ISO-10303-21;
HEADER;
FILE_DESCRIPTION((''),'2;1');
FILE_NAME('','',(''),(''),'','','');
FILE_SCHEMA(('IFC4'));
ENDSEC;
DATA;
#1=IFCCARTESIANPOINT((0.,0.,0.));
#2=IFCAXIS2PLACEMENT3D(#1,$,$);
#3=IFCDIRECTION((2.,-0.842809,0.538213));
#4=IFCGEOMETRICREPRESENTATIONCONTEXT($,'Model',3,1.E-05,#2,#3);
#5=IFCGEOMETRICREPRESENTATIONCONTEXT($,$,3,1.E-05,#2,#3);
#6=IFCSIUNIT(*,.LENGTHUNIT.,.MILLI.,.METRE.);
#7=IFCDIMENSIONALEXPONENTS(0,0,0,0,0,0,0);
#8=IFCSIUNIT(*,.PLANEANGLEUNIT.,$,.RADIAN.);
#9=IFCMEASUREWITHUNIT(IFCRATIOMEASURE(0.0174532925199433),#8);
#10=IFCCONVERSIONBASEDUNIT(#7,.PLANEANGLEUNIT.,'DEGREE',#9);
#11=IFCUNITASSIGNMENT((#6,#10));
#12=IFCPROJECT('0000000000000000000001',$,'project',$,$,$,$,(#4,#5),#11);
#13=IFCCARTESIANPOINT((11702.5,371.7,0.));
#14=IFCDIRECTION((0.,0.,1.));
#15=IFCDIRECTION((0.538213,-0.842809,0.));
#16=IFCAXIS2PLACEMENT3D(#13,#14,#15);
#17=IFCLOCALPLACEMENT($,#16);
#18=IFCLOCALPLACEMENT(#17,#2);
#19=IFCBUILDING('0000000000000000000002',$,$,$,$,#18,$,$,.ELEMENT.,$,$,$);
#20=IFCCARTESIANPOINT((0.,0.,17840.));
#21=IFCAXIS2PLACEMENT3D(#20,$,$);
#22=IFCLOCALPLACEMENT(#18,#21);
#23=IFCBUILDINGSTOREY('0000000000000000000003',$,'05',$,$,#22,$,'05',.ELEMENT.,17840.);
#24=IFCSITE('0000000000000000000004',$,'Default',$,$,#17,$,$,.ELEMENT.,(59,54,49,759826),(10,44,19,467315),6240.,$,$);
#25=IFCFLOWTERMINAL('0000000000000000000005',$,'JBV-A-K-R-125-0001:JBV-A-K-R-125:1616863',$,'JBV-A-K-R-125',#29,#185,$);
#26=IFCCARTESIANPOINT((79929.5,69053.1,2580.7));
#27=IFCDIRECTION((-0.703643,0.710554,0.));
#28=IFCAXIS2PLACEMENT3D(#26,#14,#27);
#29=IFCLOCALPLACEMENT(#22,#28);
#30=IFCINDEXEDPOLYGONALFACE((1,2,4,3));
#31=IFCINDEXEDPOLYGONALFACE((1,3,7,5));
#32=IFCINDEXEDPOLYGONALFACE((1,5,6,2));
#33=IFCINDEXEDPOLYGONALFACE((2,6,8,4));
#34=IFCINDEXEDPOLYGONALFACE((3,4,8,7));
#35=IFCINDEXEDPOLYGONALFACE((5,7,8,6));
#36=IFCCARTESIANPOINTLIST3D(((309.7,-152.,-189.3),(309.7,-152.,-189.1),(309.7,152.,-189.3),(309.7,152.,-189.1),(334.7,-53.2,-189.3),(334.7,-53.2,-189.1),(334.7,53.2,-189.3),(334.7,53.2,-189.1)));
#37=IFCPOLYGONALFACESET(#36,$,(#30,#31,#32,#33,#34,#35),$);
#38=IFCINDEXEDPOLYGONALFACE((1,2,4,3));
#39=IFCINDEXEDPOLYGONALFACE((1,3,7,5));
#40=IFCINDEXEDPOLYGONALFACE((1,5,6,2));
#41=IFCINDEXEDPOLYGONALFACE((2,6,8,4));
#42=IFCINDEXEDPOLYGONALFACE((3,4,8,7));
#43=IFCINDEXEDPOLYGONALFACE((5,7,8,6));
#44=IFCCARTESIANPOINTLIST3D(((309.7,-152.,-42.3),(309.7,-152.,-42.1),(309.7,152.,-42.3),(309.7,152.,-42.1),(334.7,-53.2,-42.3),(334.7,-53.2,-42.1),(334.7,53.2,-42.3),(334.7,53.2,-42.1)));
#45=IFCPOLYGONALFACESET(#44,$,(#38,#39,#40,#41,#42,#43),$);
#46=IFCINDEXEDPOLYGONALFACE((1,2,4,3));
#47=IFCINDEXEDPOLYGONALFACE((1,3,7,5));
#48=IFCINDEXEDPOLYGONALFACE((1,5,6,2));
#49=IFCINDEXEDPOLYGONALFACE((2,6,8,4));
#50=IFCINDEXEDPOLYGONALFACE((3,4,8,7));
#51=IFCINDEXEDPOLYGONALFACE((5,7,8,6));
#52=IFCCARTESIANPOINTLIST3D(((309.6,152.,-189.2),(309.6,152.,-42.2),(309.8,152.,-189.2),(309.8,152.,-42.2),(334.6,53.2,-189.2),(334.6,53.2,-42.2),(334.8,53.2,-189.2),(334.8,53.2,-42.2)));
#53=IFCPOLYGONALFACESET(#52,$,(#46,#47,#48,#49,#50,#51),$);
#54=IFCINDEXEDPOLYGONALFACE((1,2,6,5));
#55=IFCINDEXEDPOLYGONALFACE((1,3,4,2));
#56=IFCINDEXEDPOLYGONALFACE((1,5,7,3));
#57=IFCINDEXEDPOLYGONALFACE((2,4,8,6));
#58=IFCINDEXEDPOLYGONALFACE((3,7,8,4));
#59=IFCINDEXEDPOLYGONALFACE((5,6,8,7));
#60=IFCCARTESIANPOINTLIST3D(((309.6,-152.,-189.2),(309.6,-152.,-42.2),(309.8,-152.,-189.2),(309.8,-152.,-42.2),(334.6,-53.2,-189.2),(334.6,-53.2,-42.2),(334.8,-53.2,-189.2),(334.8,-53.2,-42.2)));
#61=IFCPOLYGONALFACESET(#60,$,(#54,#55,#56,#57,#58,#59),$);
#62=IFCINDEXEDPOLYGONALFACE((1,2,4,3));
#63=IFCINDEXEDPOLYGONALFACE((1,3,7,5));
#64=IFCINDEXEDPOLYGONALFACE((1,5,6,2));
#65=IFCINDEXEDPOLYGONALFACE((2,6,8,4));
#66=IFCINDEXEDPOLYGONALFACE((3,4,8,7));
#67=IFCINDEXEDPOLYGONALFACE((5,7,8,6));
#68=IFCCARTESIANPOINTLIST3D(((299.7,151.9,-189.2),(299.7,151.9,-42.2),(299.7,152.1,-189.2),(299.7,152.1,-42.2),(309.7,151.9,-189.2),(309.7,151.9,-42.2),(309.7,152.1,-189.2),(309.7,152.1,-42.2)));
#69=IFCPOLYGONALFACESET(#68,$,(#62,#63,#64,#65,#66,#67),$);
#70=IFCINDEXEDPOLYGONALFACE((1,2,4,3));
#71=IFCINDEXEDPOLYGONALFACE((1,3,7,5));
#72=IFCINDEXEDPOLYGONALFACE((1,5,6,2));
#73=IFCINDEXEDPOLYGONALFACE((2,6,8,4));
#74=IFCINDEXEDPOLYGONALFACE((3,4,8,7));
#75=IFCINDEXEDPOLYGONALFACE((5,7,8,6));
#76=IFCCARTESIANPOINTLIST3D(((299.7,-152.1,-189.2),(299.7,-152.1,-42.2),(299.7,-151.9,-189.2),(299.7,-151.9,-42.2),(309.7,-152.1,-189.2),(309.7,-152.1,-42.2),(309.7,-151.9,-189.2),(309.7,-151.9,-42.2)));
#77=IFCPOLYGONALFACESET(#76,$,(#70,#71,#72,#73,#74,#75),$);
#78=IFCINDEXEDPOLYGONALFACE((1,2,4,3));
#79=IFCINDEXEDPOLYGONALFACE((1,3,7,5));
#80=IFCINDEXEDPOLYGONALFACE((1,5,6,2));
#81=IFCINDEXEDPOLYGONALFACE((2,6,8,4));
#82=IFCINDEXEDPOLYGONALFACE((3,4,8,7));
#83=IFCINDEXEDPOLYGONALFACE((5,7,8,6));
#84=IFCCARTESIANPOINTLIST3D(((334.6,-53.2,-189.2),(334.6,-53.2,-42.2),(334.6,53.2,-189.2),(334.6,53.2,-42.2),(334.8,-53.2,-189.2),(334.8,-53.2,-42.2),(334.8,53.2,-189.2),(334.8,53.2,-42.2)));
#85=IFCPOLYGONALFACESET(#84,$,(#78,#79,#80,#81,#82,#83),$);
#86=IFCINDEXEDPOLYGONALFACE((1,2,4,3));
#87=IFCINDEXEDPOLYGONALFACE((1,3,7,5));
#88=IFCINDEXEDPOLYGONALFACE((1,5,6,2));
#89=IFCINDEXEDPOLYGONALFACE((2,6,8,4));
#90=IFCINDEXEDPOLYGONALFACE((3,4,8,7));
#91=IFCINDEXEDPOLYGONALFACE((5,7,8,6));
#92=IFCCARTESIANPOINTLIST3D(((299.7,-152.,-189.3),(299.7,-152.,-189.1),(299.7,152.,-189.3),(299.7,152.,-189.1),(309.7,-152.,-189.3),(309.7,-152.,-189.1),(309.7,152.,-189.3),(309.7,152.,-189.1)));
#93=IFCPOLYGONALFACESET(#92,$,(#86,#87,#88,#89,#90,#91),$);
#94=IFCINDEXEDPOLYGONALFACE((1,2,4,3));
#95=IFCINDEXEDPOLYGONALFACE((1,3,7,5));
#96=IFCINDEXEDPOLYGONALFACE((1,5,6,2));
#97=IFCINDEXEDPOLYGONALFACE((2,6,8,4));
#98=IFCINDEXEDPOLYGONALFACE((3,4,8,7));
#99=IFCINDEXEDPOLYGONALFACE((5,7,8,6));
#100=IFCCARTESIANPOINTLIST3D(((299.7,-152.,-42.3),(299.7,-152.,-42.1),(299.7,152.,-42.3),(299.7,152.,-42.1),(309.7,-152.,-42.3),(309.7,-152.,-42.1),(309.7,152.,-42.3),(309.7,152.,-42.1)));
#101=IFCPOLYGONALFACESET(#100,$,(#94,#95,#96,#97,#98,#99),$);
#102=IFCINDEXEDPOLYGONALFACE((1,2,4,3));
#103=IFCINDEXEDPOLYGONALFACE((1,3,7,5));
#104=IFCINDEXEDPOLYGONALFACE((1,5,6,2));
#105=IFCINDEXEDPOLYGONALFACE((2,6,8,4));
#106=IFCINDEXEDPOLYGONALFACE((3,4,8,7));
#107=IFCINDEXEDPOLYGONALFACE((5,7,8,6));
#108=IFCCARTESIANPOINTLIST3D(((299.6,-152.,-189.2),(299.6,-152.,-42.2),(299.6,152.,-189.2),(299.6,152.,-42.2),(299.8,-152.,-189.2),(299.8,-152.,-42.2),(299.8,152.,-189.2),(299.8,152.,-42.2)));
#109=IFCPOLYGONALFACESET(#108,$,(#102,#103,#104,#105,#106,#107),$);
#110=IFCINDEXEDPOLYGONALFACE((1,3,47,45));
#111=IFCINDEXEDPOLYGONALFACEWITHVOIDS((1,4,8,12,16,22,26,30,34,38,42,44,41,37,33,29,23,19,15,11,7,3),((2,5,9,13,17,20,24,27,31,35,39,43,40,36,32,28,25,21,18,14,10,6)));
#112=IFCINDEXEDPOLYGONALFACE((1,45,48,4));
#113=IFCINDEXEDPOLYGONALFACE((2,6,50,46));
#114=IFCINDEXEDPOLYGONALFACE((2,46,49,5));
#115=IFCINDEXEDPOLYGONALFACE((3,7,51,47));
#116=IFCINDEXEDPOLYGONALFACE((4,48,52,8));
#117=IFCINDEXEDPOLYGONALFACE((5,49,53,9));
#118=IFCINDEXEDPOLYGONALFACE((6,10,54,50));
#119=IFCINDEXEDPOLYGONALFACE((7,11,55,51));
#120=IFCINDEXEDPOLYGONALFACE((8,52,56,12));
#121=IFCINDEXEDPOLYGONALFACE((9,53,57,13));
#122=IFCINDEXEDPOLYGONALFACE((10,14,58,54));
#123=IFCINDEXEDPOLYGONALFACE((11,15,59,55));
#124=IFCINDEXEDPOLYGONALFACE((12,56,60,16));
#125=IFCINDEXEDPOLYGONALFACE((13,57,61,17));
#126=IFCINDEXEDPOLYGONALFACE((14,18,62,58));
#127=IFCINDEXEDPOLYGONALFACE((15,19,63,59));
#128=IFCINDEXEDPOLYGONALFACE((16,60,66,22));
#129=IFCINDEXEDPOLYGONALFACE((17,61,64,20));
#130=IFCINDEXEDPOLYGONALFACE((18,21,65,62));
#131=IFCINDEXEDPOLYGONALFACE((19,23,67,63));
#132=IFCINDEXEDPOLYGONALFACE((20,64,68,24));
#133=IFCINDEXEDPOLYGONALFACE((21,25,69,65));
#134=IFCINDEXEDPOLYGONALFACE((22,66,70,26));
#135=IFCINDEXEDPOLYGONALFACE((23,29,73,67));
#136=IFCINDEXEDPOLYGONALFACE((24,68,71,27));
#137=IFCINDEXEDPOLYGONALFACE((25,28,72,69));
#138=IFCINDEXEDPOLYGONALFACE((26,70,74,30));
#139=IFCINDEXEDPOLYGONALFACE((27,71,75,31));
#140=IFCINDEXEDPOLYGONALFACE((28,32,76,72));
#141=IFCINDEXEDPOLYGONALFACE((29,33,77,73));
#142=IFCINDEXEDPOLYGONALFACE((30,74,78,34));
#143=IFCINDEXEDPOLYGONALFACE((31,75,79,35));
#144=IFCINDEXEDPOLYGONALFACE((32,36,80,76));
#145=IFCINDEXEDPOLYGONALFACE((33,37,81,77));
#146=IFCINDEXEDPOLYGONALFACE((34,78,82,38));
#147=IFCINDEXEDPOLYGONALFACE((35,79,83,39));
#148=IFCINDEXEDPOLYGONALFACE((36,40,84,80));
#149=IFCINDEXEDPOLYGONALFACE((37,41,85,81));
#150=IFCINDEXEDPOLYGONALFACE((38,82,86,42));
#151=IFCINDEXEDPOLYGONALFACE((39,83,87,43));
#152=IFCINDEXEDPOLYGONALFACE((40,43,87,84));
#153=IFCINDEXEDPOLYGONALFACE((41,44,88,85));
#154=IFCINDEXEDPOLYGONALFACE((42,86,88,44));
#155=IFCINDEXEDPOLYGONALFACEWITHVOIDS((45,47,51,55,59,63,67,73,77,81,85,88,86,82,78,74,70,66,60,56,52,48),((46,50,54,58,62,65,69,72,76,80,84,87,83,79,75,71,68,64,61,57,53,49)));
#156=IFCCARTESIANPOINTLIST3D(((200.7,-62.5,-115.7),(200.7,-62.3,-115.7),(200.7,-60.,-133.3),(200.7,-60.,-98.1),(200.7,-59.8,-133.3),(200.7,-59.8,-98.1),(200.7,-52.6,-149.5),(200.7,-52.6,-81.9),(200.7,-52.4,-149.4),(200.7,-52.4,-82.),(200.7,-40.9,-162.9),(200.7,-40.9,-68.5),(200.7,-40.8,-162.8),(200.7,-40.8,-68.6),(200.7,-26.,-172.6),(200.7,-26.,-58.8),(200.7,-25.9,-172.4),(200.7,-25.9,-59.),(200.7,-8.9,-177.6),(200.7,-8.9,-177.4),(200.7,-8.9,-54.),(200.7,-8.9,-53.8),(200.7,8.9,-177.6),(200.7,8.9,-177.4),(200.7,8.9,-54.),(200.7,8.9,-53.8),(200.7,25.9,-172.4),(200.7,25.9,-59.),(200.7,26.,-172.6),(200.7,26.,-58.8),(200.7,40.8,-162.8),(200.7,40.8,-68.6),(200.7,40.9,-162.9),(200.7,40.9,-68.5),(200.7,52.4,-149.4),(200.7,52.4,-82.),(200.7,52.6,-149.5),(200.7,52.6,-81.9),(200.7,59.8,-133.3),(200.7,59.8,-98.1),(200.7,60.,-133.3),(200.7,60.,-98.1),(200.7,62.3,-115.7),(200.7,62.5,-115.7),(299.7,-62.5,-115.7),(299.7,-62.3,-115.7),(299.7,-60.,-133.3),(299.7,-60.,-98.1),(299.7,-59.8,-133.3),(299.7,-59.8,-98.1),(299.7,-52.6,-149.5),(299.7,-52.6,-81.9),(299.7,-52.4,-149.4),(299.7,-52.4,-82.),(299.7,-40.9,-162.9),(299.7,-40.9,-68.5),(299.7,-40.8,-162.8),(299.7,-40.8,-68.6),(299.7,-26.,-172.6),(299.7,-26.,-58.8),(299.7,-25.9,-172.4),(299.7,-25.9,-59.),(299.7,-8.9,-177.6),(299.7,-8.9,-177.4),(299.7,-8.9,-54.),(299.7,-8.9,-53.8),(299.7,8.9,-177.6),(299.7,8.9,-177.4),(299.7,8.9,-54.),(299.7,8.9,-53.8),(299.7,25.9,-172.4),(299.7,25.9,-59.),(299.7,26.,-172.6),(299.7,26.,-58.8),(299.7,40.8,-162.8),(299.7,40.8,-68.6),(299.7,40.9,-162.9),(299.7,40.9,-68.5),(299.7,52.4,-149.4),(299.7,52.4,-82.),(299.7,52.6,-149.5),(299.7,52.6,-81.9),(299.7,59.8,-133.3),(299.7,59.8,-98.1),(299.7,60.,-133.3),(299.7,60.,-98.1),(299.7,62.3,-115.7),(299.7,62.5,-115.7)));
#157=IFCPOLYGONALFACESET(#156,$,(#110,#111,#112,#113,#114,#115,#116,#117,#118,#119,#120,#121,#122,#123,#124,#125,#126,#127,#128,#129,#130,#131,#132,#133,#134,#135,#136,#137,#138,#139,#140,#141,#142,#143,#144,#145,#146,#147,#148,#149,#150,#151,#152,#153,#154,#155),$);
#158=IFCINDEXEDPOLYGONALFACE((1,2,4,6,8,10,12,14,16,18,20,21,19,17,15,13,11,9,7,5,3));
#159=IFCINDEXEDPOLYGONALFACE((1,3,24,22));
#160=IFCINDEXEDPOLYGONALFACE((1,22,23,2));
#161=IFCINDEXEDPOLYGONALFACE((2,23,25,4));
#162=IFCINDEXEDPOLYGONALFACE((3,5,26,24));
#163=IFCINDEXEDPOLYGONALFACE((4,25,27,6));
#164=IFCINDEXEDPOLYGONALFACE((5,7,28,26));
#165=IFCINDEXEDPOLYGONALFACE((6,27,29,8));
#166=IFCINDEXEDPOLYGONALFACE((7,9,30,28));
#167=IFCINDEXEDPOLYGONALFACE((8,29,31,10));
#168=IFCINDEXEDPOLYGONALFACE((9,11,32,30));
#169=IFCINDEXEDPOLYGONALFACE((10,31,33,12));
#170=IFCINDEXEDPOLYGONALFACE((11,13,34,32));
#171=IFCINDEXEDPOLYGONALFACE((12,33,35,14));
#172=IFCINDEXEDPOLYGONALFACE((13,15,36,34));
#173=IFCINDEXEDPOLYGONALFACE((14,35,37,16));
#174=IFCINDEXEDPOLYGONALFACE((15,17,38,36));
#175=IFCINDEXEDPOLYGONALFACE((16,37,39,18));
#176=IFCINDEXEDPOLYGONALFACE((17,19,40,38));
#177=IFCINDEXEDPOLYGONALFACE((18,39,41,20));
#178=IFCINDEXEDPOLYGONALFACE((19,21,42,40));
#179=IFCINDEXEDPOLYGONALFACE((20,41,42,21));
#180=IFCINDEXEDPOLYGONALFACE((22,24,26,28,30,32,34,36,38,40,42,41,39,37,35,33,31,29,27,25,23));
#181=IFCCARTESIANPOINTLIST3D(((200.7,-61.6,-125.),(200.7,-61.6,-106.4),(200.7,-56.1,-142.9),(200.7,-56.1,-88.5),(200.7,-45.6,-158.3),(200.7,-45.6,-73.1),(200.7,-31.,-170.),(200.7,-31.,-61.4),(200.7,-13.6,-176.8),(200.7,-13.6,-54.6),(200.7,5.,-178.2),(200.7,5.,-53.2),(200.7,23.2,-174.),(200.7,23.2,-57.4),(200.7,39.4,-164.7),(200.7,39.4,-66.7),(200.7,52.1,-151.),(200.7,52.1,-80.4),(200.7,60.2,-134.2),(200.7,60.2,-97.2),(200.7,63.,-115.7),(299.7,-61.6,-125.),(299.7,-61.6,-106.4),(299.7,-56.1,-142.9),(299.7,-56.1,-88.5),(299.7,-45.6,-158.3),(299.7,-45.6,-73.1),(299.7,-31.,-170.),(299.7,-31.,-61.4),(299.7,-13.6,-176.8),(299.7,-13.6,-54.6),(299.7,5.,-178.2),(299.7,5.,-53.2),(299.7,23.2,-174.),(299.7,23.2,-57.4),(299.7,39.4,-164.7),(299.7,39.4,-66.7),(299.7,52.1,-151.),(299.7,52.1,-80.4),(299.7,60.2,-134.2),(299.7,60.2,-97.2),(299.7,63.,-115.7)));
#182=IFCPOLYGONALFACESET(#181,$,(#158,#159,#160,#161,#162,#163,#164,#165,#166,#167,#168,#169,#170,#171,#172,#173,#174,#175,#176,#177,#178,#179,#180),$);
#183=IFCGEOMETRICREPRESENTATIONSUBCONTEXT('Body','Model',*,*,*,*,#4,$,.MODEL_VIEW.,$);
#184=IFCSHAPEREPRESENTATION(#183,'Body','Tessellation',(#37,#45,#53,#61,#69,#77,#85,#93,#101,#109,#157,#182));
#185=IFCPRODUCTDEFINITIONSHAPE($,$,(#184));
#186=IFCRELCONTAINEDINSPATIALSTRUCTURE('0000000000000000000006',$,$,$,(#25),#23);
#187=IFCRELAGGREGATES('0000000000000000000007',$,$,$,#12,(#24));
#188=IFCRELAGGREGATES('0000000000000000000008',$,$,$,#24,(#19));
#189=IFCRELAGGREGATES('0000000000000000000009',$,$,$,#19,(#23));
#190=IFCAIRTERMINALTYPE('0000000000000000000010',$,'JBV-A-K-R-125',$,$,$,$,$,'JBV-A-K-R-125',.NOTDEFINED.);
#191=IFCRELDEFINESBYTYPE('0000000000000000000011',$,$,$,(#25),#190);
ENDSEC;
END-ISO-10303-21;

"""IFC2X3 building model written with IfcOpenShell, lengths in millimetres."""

from ifc_helpers import new_model, entity, si_unit, converted_unit, direction, frame, frame_2d, origin, origin_2d_with_axis, place, context, subcontext, project, spatial, polyline, circle_curve, parameter, trimmed, segment, composite_curve, rectangle, circle, outline, extrude, source, transform, mapped, type_object, type_shapes, element, save


model = new_model("IFC2X3")

# Units and contexts
model_context = context("Model", 3, precision=1e-05, world=origin(), true_north=direction((2.0, -0.842809, 0.538213)))
context_of_model = context(None, 3, precision=1e-05, world=origin(), true_north=direction((2.0, -0.842809, 0.538213)))
body_context = subcontext(model_context, "Body", "Model", "MODEL_VIEW")
ifc_project = project(units=[si_unit("LENGTHUNIT", "METRE", prefix="MILLI"), converted_unit("PLANEANGLEUNIT", "DEGREE", entity("IfcRatioMeasure", 0.0174532925199433), si_unit("PLANEANGLEUNIT", "RADIAN"), dimensions=[0, 0, 0, 0, 0, 0, 0])], contexts=[model_context, context_of_model])

# Site, building, storey
site_placement = place(None, frame((11702.5, 371.7, 0.0), z_axis=(0.0, 0.0, 1.0), x_axis=(0.538213, -0.842809, 0.0)))
site = spatial("IfcSite", under=ifc_project, at=site_placement, Name="Default", CompositionType="ELEMENT", RefLatitude=(59, 54, 49, 759826), RefLongitude=(10, 44, 19, 467315), RefElevation=6240.0)
building_placement = place(site_placement, origin())
building = spatial("IfcBuilding", under=site, at=building_placement, CompositionType="ELEMENT")
storey_placement = place(building_placement, frame((0.0, 0.0, 17840.0)))
storey = spatial("IfcBuildingStorey", under=building, at=storey_placement, Name="05", LongName="05", CompositionType="ELEMENT", Elevation=17840.0)

# Flow terminal
air_terminal_type_1 = type_object("IfcAirTerminalType", Name="JBV-A-K-R-125", ElementType="JBV-A-K-R-125", PredefinedType="NOTDEFINED")
shared_shape_1 = source(origin(), body_context, "Body", "SweptSolid", [
    extrude(outline(polyline([(-152.0, -12.5), (152.0, -12.5), (53.2, 12.5), (-53.2, 12.5), (-152.0, -12.5)])), frame((322.2, 0.0, -189.3), z_axis=(0.0, 0.0, 1.0), x_axis=(0.0, -1.0, 0.0)), (0.0, 0.0, 1.0), 0.2),
    extrude(outline(polyline([(-152.0, -12.5), (152.0, -12.5), (53.2, 12.5), (-53.2, 12.5), (-152.0, -12.5)])), frame((322.2, 0.0, -42.3), z_axis=(0.0, 0.0, 1.0), x_axis=(0.0, -1.0, 0.0)), (0.0, 0.0, 1.0), 0.2),
    extrude(rectangle(XDim=0.2, YDim=101.9, at=frame_2d((0.0, 0.0), x_axis=(1.0, 0.0))), frame((322.2, 102.6, -189.2), z_axis=(0.0, 0.0, 1.0), x_axis=(0.969446, 0.245305, 0.0)), (0.0, 0.0, 1.0), 147.0),
    extrude(rectangle(XDim=0.2, YDim=101.9, at=frame_2d((0.0, 0.0), x_axis=(1.0, 0.0))), frame((322.2, -102.6, -189.2), z_axis=(0.0, 0.0, 1.0), x_axis=(-0.969446, 0.245305, 0.0)), (0.0, 0.0, 1.0), 147.0),
    extrude(rectangle(XDim=0.2, YDim=10.0, at=frame_2d((0.0, 0.0), x_axis=(1.0, 0.0))), frame((304.7, 152.0, -189.2), z_axis=(0.0, 0.0, 1.0), x_axis=(0.0, 1.0, 0.0)), (0.0, 0.0, 1.0), 147.0),
    extrude(rectangle(XDim=0.2, YDim=10.0, at=frame_2d((0.0, 0.0), x_axis=(1.0, 0.0))), frame((304.7, -152.0, -189.2), z_axis=(0.0, 0.0, 1.0), x_axis=(0.0, 1.0, 0.0)), (0.0, 0.0, 1.0), 147.0),
    extrude(rectangle(XDim=0.2, YDim=106.4, at=frame_2d((0.0, 0.0), x_axis=(1.0, 0.0))), frame((334.7, 0.0, -189.2)), (0.0, 0.0, 1.0), 147.0),
    extrude(rectangle(XDim=304.0, YDim=10.0, at=frame_2d((0.0, 0.0), x_axis=(1.0, 0.0))), frame((304.7, 0.0, -189.3), z_axis=(0.0, 0.0, 1.0), x_axis=(0.0, -1.0, 0.0)), (0.0, 0.0, 1.0), 0.2),
    extrude(rectangle(XDim=304.0, YDim=10.0, at=frame_2d((0.0, 0.0), x_axis=(1.0, 0.0))), frame((304.7, 0.0, -42.3), z_axis=(0.0, 0.0, 1.0), x_axis=(0.0, -1.0, 0.0)), (0.0, 0.0, 1.0), 0.2),
    extrude(rectangle(XDim=0.2, YDim=304.0, at=frame_2d((0.0, 0.0), x_axis=(1.0, 0.0))), frame((299.7, 0.0, -189.2)), (0.0, 0.0, 1.0), 147.0),
    extrude(outline(composite_curve([segment(trimmed(circle_curve(origin_2d_with_axis(), 62.5), [parameter(0.0)], [parameter(180.0)], True, "PARAMETER"), True, "CONTINUOUS"), segment(trimmed(circle_curve(origin_2d_with_axis(), 62.5), [parameter(180.0)], [parameter(360.0)], True, "PARAMETER"), True, "CONTINUOUS")], self_intersect=False), holes=[composite_curve([segment(trimmed(circle_curve(origin_2d_with_axis(), 62.3), [parameter(180.0)], [parameter(360.0)], True, "PARAMETER"), False, "CONTINUOUS"), segment(trimmed(circle_curve(origin_2d_with_axis(), 62.3), [parameter(0.0)], [parameter(180.0)], True, "PARAMETER"), False, "CONTINUOUS")], self_intersect=False)]), frame((200.7, 0.0, -115.7), z_axis=(1.0, 0.0, 0.0), x_axis=(0.0, 1.0, 0.0)), (0.0, 0.0, 1.0), 99.0),
    extrude(circle(Radius=62.6, at=frame_2d((0.0, 0.0), x_axis=(1.0, 0.0))), frame((200.7, 0.3, -115.7), z_axis=(1.0, 0.0, 0.0), x_axis=(0.0, 1.0, 0.0)), (0.0, 0.0, 1.0), 99.0),
])
type_shapes(air_terminal_type_1, [shared_shape_1])
for number, where, z_axis, x_axis, name in (
    (1, (79929.5, 69053.1, 2580.7), (0.0, 0.0, 1.0), (-0.703643, 0.710554, 0.0), "JBV-A-K-R-125-0001:JBV-A-K-R-125:1616863"),
):
    element("IfcFlowTerminal", number, at=place(storey_placement, frame(where, z_axis=z_axis, x_axis=x_axis)), inside=storey, type_object=air_terminal_type_1, Name=name, ObjectType="JBV-A-K-R-125", context=body_context, shape_type="MappedRepresentation", body=[
        mapped(shared_shape_1, transform((0.0, 0.0, 0.0), scale=1.0)),
    ])

save(model, "model.ifc")
